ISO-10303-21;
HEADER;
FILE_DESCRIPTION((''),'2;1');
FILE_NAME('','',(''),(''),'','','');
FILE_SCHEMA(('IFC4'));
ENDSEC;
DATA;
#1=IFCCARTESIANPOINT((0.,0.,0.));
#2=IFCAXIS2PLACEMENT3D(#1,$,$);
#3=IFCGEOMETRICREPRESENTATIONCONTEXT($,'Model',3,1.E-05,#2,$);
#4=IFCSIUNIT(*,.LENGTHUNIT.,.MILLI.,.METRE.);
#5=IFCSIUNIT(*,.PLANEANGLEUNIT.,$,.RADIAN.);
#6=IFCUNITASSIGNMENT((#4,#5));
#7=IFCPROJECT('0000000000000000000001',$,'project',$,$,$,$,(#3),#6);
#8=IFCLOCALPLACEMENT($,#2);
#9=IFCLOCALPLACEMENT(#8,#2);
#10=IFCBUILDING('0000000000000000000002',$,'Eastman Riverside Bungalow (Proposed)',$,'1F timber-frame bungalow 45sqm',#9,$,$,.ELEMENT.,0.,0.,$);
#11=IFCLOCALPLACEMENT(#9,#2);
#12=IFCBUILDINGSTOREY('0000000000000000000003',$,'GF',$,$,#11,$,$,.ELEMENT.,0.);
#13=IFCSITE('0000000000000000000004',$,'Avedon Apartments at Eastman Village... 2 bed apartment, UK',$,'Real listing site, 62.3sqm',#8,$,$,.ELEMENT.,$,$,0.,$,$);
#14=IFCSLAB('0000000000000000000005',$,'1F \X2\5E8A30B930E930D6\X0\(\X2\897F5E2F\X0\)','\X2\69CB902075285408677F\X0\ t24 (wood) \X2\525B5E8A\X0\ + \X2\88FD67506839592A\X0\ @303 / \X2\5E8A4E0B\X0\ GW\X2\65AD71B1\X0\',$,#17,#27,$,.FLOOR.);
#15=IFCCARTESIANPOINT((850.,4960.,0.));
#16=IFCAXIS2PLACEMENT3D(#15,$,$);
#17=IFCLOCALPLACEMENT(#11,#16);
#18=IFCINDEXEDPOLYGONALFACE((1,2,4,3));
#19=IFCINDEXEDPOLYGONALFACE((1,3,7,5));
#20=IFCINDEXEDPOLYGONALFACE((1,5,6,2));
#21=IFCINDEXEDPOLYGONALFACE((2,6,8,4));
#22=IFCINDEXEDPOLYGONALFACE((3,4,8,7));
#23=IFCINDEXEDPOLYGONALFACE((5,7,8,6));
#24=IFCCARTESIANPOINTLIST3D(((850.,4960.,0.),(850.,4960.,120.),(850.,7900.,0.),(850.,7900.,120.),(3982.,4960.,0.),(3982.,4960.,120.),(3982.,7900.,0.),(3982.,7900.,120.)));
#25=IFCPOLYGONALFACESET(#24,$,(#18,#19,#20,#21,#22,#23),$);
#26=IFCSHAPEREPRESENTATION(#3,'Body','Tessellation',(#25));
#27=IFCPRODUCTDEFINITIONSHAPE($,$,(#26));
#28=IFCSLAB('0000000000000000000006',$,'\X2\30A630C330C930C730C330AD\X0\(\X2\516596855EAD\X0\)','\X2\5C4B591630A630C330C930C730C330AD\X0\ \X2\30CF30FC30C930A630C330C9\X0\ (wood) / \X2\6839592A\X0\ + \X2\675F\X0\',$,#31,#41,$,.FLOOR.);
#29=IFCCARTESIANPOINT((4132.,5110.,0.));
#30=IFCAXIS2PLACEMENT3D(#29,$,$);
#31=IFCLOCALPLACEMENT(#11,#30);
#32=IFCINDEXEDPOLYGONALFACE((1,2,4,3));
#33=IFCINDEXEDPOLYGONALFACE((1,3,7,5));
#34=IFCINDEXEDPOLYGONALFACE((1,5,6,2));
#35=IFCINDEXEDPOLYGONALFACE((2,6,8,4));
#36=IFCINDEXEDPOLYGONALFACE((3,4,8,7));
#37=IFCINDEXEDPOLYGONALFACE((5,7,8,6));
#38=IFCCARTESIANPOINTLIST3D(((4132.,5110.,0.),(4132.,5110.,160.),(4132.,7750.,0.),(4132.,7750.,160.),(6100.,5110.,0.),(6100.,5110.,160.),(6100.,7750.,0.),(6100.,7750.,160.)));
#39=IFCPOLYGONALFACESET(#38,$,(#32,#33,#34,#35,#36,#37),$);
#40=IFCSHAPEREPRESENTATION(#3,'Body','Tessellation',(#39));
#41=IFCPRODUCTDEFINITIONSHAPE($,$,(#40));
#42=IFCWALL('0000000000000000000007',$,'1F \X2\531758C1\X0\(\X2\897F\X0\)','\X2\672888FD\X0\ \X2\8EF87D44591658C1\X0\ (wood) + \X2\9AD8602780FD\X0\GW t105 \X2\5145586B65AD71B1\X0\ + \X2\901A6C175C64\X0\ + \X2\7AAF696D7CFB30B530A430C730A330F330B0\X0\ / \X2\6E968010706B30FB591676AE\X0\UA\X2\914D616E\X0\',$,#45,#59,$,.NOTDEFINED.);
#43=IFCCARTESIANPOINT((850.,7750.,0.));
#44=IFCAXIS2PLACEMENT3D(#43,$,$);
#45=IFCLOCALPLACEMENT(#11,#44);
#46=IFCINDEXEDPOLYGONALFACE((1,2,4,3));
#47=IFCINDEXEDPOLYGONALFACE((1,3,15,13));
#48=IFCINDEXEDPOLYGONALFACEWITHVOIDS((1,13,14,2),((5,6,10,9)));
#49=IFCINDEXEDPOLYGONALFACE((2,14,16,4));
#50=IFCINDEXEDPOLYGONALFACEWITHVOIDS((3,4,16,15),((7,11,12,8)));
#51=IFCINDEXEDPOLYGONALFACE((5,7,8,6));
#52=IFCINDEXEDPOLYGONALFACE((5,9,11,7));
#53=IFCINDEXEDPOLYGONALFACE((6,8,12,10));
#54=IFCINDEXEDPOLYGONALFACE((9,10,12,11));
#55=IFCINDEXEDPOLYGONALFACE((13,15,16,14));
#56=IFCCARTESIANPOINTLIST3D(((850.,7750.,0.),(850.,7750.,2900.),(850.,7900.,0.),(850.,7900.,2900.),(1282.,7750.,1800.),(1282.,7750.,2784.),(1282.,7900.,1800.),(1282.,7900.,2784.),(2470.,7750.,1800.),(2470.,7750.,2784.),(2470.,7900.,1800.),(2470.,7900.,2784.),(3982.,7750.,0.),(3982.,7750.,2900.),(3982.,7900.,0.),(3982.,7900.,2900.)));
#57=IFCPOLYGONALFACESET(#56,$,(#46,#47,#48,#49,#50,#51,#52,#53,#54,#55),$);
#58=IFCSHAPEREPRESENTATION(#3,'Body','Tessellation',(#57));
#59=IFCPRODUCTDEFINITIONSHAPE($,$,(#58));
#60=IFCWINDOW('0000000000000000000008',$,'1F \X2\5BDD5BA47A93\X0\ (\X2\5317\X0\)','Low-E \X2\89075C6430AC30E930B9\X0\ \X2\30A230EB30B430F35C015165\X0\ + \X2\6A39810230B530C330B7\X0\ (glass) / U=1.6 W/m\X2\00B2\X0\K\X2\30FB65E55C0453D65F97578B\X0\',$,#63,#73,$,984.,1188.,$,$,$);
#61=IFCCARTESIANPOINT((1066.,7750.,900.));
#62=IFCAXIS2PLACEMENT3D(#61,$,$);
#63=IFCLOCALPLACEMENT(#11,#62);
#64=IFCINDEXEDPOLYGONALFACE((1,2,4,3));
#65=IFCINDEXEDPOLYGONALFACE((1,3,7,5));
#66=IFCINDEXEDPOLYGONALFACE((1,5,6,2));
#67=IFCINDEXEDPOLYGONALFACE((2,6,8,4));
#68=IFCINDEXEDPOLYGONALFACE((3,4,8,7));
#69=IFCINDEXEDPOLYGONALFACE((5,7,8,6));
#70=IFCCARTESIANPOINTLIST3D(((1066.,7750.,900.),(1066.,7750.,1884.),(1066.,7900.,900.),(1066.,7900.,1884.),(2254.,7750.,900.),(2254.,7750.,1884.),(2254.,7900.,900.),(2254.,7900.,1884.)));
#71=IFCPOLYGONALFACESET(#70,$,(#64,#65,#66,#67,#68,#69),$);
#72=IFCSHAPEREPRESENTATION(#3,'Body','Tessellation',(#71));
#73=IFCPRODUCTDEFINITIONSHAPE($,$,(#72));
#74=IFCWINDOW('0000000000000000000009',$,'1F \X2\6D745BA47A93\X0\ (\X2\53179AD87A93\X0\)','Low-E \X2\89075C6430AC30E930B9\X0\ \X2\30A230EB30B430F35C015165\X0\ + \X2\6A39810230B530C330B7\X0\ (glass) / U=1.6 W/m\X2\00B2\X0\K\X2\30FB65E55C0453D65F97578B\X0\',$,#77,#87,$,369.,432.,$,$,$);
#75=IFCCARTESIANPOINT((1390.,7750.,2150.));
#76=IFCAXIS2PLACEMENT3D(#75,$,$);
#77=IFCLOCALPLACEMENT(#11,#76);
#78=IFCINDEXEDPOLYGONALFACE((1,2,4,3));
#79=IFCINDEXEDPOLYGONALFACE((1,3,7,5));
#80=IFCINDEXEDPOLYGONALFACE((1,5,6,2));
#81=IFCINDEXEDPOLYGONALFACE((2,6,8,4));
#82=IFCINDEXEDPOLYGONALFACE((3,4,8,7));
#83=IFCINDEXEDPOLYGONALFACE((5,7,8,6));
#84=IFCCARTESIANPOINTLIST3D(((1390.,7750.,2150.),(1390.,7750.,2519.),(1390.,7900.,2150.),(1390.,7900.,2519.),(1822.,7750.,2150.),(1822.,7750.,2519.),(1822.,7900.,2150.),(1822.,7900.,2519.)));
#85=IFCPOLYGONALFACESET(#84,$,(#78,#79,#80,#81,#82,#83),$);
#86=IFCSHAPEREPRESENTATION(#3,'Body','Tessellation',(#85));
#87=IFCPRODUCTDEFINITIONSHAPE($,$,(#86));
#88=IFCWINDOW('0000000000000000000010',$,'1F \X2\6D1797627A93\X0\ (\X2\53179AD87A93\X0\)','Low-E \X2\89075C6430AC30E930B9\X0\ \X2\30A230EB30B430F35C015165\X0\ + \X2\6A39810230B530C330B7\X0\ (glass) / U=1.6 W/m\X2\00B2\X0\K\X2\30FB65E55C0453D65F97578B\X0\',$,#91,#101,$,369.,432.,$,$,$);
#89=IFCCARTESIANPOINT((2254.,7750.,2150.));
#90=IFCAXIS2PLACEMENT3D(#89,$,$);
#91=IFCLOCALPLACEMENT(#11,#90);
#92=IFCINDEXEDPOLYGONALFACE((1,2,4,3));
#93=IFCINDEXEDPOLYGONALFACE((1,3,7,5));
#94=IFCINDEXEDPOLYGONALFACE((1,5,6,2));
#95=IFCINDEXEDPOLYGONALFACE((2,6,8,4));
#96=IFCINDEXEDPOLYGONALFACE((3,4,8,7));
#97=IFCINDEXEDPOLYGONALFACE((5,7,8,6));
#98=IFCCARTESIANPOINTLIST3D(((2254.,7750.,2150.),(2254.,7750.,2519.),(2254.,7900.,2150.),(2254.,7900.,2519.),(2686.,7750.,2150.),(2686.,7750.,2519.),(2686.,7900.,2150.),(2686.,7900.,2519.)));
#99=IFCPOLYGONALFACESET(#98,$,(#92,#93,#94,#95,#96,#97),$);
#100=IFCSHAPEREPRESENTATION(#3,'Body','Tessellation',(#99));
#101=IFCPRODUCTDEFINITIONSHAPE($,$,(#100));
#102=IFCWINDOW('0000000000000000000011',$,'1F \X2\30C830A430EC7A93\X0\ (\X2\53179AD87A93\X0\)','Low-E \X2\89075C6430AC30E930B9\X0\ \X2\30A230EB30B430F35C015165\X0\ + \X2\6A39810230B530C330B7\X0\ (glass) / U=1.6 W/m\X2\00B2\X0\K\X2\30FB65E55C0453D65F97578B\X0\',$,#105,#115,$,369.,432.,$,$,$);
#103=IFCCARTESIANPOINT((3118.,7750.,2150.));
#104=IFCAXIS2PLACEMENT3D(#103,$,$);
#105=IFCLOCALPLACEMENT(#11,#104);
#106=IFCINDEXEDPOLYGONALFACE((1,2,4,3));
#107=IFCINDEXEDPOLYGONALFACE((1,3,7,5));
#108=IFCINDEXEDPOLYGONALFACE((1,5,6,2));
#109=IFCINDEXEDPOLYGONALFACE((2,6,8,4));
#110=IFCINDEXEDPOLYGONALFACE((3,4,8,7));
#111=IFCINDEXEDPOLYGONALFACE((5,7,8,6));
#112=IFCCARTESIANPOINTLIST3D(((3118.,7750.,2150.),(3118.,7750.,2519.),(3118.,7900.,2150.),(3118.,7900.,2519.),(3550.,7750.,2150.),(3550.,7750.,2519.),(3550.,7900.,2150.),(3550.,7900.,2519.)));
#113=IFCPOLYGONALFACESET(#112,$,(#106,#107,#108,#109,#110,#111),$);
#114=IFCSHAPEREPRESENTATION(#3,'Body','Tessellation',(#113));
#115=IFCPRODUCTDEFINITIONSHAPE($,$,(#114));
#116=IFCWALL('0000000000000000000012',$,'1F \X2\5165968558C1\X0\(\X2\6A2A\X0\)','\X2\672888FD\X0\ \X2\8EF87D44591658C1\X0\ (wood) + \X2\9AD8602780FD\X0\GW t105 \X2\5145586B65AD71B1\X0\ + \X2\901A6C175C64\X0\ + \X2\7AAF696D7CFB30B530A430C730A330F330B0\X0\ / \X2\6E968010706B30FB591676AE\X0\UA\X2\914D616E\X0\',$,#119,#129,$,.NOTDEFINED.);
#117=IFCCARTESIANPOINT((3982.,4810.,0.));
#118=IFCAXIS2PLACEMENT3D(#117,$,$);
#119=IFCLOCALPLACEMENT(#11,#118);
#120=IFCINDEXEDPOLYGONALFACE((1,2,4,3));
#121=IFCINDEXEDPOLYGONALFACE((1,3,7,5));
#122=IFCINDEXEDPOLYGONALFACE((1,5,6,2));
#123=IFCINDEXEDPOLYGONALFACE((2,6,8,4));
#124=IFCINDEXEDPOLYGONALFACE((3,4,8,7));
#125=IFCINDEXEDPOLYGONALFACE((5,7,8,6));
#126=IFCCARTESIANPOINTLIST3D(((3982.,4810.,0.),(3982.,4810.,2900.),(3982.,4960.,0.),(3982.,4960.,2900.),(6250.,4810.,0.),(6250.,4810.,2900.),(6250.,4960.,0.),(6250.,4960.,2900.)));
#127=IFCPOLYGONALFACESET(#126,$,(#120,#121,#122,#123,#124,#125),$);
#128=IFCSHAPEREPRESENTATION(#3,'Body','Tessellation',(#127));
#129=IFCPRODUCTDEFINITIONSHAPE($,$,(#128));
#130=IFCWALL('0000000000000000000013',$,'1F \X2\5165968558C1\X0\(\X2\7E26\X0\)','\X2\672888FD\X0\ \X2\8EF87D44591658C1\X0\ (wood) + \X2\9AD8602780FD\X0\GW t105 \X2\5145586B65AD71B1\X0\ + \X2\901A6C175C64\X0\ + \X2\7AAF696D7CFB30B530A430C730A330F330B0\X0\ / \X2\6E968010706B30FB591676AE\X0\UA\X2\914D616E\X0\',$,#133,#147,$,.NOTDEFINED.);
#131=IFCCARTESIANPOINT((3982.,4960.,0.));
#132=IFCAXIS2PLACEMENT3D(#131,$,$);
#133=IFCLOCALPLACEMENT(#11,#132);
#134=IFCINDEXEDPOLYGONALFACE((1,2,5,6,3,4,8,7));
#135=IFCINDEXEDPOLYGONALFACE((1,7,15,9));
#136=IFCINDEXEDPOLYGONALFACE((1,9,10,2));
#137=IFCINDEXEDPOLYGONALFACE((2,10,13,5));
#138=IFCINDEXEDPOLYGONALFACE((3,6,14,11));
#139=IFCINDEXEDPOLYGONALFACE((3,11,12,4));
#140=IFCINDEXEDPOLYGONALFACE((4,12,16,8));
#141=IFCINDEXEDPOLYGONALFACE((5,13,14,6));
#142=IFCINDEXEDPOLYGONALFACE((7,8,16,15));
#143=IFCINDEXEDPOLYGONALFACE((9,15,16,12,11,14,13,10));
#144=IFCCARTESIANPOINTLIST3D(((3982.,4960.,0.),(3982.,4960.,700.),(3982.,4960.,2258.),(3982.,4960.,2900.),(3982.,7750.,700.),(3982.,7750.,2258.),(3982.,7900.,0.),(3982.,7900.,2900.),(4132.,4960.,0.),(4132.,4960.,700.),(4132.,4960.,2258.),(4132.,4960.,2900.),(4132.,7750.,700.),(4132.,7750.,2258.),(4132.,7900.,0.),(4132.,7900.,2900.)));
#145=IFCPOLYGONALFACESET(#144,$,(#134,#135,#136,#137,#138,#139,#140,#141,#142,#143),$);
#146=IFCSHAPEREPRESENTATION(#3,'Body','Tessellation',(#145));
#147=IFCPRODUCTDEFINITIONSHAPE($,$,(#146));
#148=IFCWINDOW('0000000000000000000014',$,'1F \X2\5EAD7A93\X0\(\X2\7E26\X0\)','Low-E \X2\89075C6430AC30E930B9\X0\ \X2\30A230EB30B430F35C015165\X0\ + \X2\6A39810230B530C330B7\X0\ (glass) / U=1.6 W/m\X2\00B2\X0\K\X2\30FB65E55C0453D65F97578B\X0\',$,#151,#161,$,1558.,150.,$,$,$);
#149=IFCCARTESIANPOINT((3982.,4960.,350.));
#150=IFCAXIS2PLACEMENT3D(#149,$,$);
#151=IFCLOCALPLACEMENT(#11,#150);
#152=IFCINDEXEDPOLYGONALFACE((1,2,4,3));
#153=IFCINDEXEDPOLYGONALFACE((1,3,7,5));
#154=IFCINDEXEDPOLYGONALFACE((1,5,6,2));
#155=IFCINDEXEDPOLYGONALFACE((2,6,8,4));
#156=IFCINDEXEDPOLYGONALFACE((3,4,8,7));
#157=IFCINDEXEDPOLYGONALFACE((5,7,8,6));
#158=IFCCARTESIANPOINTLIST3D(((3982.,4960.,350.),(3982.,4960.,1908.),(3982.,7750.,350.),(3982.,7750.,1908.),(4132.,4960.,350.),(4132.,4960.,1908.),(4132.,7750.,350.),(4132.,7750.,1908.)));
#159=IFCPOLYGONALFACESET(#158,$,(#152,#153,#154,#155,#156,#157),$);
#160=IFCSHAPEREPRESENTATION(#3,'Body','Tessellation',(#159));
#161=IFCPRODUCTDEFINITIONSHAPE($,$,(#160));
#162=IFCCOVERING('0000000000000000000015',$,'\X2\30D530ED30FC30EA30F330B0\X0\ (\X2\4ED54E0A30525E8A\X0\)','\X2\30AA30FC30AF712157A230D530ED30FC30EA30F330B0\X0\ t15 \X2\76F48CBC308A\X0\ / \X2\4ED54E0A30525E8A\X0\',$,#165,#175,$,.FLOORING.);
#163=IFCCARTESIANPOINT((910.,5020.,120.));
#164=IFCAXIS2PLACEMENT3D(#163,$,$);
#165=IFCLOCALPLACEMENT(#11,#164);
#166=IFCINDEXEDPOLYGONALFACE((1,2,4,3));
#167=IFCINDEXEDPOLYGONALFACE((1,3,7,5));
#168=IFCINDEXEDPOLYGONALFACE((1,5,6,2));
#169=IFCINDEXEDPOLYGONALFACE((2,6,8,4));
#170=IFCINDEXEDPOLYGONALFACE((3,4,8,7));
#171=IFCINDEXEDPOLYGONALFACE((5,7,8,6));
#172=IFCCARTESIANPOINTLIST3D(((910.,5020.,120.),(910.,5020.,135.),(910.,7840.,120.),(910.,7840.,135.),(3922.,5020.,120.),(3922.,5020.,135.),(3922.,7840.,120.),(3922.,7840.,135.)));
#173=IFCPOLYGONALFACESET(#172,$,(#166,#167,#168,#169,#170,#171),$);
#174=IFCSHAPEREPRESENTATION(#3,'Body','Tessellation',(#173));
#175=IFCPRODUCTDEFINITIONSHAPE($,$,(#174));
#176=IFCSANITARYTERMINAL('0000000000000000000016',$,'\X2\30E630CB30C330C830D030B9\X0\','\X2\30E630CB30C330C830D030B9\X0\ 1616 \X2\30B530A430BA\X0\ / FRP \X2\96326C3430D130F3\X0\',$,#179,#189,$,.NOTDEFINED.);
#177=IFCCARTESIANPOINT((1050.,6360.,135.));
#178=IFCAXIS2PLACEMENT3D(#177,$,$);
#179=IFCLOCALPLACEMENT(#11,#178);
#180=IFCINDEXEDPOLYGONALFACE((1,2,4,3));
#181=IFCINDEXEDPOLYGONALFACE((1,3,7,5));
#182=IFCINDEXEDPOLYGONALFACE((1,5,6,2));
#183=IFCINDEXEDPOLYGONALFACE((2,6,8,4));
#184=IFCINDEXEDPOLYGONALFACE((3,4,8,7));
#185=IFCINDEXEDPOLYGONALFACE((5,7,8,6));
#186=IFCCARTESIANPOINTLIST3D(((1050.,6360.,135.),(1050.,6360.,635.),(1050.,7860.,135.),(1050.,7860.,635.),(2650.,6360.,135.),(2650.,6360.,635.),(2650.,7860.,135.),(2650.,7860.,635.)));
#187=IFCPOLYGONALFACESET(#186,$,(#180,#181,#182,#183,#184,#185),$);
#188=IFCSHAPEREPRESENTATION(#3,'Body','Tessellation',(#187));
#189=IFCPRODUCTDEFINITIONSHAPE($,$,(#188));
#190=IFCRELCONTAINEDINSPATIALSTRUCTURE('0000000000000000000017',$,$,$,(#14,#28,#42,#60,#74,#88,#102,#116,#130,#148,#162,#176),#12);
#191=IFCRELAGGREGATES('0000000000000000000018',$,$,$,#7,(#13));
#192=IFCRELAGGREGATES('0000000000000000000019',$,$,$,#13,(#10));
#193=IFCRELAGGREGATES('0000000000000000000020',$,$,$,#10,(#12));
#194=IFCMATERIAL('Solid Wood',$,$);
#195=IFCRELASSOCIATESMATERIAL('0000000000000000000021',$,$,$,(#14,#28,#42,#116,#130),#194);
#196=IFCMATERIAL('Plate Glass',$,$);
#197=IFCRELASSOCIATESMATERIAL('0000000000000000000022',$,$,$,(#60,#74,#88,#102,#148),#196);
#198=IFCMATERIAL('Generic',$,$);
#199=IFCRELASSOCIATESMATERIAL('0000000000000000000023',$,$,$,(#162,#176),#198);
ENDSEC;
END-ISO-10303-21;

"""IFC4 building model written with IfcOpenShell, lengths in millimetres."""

from ifc_helpers import new_model, si_unit, frame, frame_2d, origin, place, context, project, spatial, rectangle, extrude, material, element, fill, save


model = new_model("IFC4")

# Units and contexts
model_context = context("Model", 3, precision=1e-05, world=origin())
ifc_project = project(units=[si_unit("LENGTHUNIT", "METRE", prefix="MILLI"), si_unit("PLANEANGLEUNIT", "RADIAN")], contexts=[model_context])

# Site, building, storey
site_placement = place(None, origin())
site = spatial("IfcSite", under=ifc_project, at=site_placement, Name="Avedon Apartments at Eastman Village... 2 bed apartment, UK", ObjectType="Real listing site, 62.3sqm", CompositionType="ELEMENT", RefElevation=0.0)
building_placement = place(site_placement, origin())
building = spatial("IfcBuilding", under=site, at=building_placement, Name="Eastman Riverside Bungalow (Proposed)", ObjectType="1F timber-frame bungalow 45sqm", CompositionType="ELEMENT", ElevationOfRefHeight=0.0, ElevationOfTerrain=0.0)
storey_placement = place(building_placement, origin())
storey = spatial("IfcBuildingStorey", under=building, at=storey_placement, Name="GF", CompositionType="ELEMENT", Elevation=0.0)

# Slabs
ifc_material_1 = material(Name="Solid Wood")
slab_1_placement = place(storey_placement, frame((850.0, 4960.0, 0.0)))
element("IfcSlab", 1, at=slab_1_placement, inside=storey, material=ifc_material_1, Name="1F 床スラブ(西帯)", Description="構造用合板 t24 (wood) 剛床 + 製材根太 @303 / 床下 GW断熱", PredefinedType="FLOOR", context=model_context, shape_type="SweptSolid", body=[
    extrude(rectangle(XDim=3132.0, YDim=2940.0, at=frame_2d((1566.0, 1470.0))), frame((850.0, 4960.0, 0.0)), (0.0, 0.0, 1.0), 120.0),
])
slab_2_placement = place(storey_placement, frame((4132.0, 5110.0, 0.0)))
element("IfcSlab", 2, at=slab_2_placement, inside=storey, material=ifc_material_1, Name="ウッドデッキ(入隅庭)", Description="屋外ウッドデッキ ハードウッド (wood) / 根太 + 束", PredefinedType="FLOOR", context=model_context, shape_type="SweptSolid", body=[
    extrude(rectangle(XDim=1968.0, YDim=2640.0, at=frame_2d((984.0, 1320.0))), frame((4132.0, 5110.0, 0.0)), (0.0, 0.0, 1.0), 160.0),
])

# Wall, openings, windows
wall_1_placement = place(storey_placement, frame((850.0, 7750.0, 0.0)))
wall_1 = element("IfcWall", 3, at=wall_1_placement, inside=storey, material=ifc_material_1, Name="1F 北壁(西)", Description="木製 軸組外壁 (wood) + 高性能GW t105 充填断熱 + 通気層 + 窯業系サイディング / 準耐火・外皮UA配慮", PredefinedType="NOTDEFINED", context=model_context, shape_type="SweptSolid", body=[
    extrude(rectangle(XDim=3132.0, YDim=150.0, at=frame_2d((1566.0, 75.0))), frame((850.0, 7750.0, 0.0)), (0.0, 0.0, 1.0), 2900.0),
])
opening_1_placement = place(storey_placement, frame((1066.0, 7750.0, 900.0)))
opening_1 = element("IfcOpeningElement", 4, at=opening_1_placement, cuts=wall_1, PredefinedType="NOTDEFINED", context=model_context, shape_type="SweptSolid", body=[
    extrude(rectangle(XDim=1188.0, YDim=150.0, at=frame_2d((594.0, 75.0))), frame((1066.0, 7750.0, 900.0)), (0.0, 0.0, 1.0), 984.0),
])
opening_2_placement = place(storey_placement, frame((1390.0, 7750.0, 2150.0)))
opening_2 = element("IfcOpeningElement", 5, at=opening_2_placement, cuts=wall_1, PredefinedType="NOTDEFINED", context=model_context, shape_type="SweptSolid", body=[
    extrude(rectangle(XDim=432.0, YDim=150.0, at=frame_2d((216.0, 75.0))), frame((1390.0, 7750.0, 2150.0)), (0.0, 0.0, 1.0), 369.0),
])
opening_3_placement = place(storey_placement, frame((2254.0, 7750.0, 2150.0)))
opening_3 = element("IfcOpeningElement", 6, at=opening_3_placement, cuts=wall_1, PredefinedType="NOTDEFINED", context=model_context, shape_type="SweptSolid", body=[
    extrude(rectangle(XDim=432.0, YDim=150.0, at=frame_2d((216.0, 75.0))), frame((2254.0, 7750.0, 2150.0)), (0.0, 0.0, 1.0), 369.0),
])
opening_4_placement = place(storey_placement, frame((3118.0, 7750.0, 2150.0)))
opening_4 = element("IfcOpeningElement", 7, at=opening_4_placement, cuts=wall_1, PredefinedType="NOTDEFINED", context=model_context, shape_type="SweptSolid", body=[
    extrude(rectangle(XDim=432.0, YDim=150.0, at=frame_2d((216.0, 75.0))), frame((3118.0, 7750.0, 2150.0)), (0.0, 0.0, 1.0), 369.0),
])
ifc_material_2 = material(Name="Plate Glass")
window_1_placement = place(storey_placement, frame((1066.0, 7750.0, 900.0)))
window_1 = element("IfcWindow", 8, at=window_1_placement, inside=storey, material=ifc_material_2, Name="1F 寝室窓 (北)", Description="Low-E 複層ガラス アルゴン封入 + 樹脂サッシ (glass) / U=1.6 W/m²K・日射取得型", OverallHeight=984.0, OverallWidth=1188.0, context=model_context, shape_type="SweptSolid", body=[
    extrude(rectangle(XDim=1188.0, YDim=150.0, at=frame_2d((594.0, 75.0))), frame((1066.0, 7750.0, 900.0)), (0.0, 0.0, 1.0), 984.0),
])
fill(opening_1, window_1)
window_2_placement = place(storey_placement, frame((1390.0, 7750.0, 2150.0)))
window_2 = element("IfcWindow", 9, at=window_2_placement, inside=storey, material=ifc_material_2, Name="1F 浴室窓 (北高窓)", Description="Low-E 複層ガラス アルゴン封入 + 樹脂サッシ (glass) / U=1.6 W/m²K・日射取得型", OverallHeight=369.0, OverallWidth=432.0, context=model_context, shape_type="SweptSolid", body=[
    extrude(rectangle(XDim=432.0, YDim=150.0, at=frame_2d((216.0, 75.0))), frame((1390.0, 7750.0, 2150.0)), (0.0, 0.0, 1.0), 369.0),
])
fill(opening_2, window_2)
window_3_placement = place(storey_placement, frame((2254.0, 7750.0, 2150.0)))
window_3 = element("IfcWindow", 10, at=window_3_placement, inside=storey, material=ifc_material_2, Name="1F 洗面窓 (北高窓)", Description="Low-E 複層ガラス アルゴン封入 + 樹脂サッシ (glass) / U=1.6 W/m²K・日射取得型", OverallHeight=369.0, OverallWidth=432.0, context=model_context, shape_type="SweptSolid", body=[
    extrude(rectangle(XDim=432.0, YDim=150.0, at=frame_2d((216.0, 75.0))), frame((2254.0, 7750.0, 2150.0)), (0.0, 0.0, 1.0), 369.0),
])
fill(opening_3, window_3)
window_4_placement = place(storey_placement, frame((3118.0, 7750.0, 2150.0)))
window_4 = element("IfcWindow", 11, at=window_4_placement, inside=storey, material=ifc_material_2, Name="1F トイレ窓 (北高窓)", Description="Low-E 複層ガラス アルゴン封入 + 樹脂サッシ (glass) / U=1.6 W/m²K・日射取得型", OverallHeight=369.0, OverallWidth=432.0, context=model_context, shape_type="SweptSolid", body=[
    extrude(rectangle(XDim=432.0, YDim=150.0, at=frame_2d((216.0, 75.0))), frame((3118.0, 7750.0, 2150.0)), (0.0, 0.0, 1.0), 369.0),
])
fill(opening_4, window_4)

# Wall
wall_2_placement = place(storey_placement, frame((3982.0, 4810.0, 0.0)))
element("IfcWall", 12, at=wall_2_placement, inside=storey, material=ifc_material_1, Name="1F 入隅壁(横)", Description="木製 軸組外壁 (wood) + 高性能GW t105 充填断熱 + 通気層 + 窯業系サイディング / 準耐火・外皮UA配慮", PredefinedType="NOTDEFINED", context=model_context, shape_type="SweptSolid", body=[
    extrude(rectangle(XDim=2268.0, YDim=150.0, at=frame_2d((1134.0, 75.0))), frame((3982.0, 4810.0, 0.0)), (0.0, 0.0, 1.0), 2900.0),
])

# Wall, opening, window
wall_3_placement = place(storey_placement, frame((3982.0, 4960.0, 0.0)))
wall_3 = element("IfcWall", 13, at=wall_3_placement, inside=storey, material=ifc_material_1, Name="1F 入隅壁(縦)", Description="木製 軸組外壁 (wood) + 高性能GW t105 充填断熱 + 通気層 + 窯業系サイディング / 準耐火・外皮UA配慮", PredefinedType="NOTDEFINED", context=model_context, shape_type="SweptSolid", body=[
    extrude(rectangle(XDim=150.0, YDim=2940.0, at=frame_2d((75.0, 1470.0))), frame((3982.0, 4960.0, 0.0)), (0.0, 0.0, 1.0), 2900.0),
])
opening_5_placement = place(storey_placement, frame((3982.0, 4960.0, 350.0)))
opening_5 = element("IfcOpeningElement", 14, at=opening_5_placement, cuts=wall_3, PredefinedType="NOTDEFINED", context=model_context, shape_type="SweptSolid", body=[
    extrude(rectangle(XDim=150.0, YDim=2790.0, at=frame_2d((75.0, 1395.0))), frame((3982.0, 4960.0, 350.0)), (0.0, 0.0, 1.0), 1558.0),
])
window_5_placement = place(storey_placement, frame((3982.0, 4960.0, 350.0)))
window_5 = element("IfcWindow", 15, at=window_5_placement, inside=storey, material=ifc_material_2, Name="1F 庭窓(縦)", Description="Low-E 複層ガラス アルゴン封入 + 樹脂サッシ (glass) / U=1.6 W/m²K・日射取得型", OverallHeight=1558.0, OverallWidth=150.0, context=model_context, shape_type="SweptSolid", body=[
    extrude(rectangle(XDim=150.0, YDim=2790.0, at=frame_2d((75.0, 1395.0))), frame((3982.0, 4960.0, 350.0)), (0.0, 0.0, 1.0), 1558.0),
])
fill(opening_5, window_5)

# Covering
ifc_material_3 = material(Name="Generic")
covering_placement = place(storey_placement, frame((910.0, 5020.0, 120.0)))
element("IfcCovering", 16, at=covering_placement, inside=storey, material=ifc_material_3, Name="フローリング (仕上げ床)", Description="オーク無垢フローリング t15 直貼り / 仕上げ床", PredefinedType="FLOORING", context=model_context, shape_type="SweptSolid", body=[
    extrude(rectangle(XDim=3012.0, YDim=2820.0, at=frame_2d((1506.0, 1410.0))), frame((910.0, 5020.0, 120.0)), (0.0, 0.0, 1.0), 15.0),
])

# Sanitary terminal
sanitary_terminal_1_placement = place(storey_placement, frame((1050.0, 6360.0, 135.0)))
element("IfcSanitaryTerminal", 17, at=sanitary_terminal_1_placement, inside=storey, material=ifc_material_3, Name="ユニットバス", Description="ユニットバス 1616 サイズ / FRP 防水パン", PredefinedType="NOTDEFINED", context=model_context, shape_type="SweptSolid", body=[
    extrude(rectangle(XDim=1600.0, YDim=1500.0, at=frame_2d((800.0, 750.0))), frame((1050.0, 6360.0, 135.0)), (0.0, 0.0, 1.0), 500.0),
])

save(model, "model.ifc")
